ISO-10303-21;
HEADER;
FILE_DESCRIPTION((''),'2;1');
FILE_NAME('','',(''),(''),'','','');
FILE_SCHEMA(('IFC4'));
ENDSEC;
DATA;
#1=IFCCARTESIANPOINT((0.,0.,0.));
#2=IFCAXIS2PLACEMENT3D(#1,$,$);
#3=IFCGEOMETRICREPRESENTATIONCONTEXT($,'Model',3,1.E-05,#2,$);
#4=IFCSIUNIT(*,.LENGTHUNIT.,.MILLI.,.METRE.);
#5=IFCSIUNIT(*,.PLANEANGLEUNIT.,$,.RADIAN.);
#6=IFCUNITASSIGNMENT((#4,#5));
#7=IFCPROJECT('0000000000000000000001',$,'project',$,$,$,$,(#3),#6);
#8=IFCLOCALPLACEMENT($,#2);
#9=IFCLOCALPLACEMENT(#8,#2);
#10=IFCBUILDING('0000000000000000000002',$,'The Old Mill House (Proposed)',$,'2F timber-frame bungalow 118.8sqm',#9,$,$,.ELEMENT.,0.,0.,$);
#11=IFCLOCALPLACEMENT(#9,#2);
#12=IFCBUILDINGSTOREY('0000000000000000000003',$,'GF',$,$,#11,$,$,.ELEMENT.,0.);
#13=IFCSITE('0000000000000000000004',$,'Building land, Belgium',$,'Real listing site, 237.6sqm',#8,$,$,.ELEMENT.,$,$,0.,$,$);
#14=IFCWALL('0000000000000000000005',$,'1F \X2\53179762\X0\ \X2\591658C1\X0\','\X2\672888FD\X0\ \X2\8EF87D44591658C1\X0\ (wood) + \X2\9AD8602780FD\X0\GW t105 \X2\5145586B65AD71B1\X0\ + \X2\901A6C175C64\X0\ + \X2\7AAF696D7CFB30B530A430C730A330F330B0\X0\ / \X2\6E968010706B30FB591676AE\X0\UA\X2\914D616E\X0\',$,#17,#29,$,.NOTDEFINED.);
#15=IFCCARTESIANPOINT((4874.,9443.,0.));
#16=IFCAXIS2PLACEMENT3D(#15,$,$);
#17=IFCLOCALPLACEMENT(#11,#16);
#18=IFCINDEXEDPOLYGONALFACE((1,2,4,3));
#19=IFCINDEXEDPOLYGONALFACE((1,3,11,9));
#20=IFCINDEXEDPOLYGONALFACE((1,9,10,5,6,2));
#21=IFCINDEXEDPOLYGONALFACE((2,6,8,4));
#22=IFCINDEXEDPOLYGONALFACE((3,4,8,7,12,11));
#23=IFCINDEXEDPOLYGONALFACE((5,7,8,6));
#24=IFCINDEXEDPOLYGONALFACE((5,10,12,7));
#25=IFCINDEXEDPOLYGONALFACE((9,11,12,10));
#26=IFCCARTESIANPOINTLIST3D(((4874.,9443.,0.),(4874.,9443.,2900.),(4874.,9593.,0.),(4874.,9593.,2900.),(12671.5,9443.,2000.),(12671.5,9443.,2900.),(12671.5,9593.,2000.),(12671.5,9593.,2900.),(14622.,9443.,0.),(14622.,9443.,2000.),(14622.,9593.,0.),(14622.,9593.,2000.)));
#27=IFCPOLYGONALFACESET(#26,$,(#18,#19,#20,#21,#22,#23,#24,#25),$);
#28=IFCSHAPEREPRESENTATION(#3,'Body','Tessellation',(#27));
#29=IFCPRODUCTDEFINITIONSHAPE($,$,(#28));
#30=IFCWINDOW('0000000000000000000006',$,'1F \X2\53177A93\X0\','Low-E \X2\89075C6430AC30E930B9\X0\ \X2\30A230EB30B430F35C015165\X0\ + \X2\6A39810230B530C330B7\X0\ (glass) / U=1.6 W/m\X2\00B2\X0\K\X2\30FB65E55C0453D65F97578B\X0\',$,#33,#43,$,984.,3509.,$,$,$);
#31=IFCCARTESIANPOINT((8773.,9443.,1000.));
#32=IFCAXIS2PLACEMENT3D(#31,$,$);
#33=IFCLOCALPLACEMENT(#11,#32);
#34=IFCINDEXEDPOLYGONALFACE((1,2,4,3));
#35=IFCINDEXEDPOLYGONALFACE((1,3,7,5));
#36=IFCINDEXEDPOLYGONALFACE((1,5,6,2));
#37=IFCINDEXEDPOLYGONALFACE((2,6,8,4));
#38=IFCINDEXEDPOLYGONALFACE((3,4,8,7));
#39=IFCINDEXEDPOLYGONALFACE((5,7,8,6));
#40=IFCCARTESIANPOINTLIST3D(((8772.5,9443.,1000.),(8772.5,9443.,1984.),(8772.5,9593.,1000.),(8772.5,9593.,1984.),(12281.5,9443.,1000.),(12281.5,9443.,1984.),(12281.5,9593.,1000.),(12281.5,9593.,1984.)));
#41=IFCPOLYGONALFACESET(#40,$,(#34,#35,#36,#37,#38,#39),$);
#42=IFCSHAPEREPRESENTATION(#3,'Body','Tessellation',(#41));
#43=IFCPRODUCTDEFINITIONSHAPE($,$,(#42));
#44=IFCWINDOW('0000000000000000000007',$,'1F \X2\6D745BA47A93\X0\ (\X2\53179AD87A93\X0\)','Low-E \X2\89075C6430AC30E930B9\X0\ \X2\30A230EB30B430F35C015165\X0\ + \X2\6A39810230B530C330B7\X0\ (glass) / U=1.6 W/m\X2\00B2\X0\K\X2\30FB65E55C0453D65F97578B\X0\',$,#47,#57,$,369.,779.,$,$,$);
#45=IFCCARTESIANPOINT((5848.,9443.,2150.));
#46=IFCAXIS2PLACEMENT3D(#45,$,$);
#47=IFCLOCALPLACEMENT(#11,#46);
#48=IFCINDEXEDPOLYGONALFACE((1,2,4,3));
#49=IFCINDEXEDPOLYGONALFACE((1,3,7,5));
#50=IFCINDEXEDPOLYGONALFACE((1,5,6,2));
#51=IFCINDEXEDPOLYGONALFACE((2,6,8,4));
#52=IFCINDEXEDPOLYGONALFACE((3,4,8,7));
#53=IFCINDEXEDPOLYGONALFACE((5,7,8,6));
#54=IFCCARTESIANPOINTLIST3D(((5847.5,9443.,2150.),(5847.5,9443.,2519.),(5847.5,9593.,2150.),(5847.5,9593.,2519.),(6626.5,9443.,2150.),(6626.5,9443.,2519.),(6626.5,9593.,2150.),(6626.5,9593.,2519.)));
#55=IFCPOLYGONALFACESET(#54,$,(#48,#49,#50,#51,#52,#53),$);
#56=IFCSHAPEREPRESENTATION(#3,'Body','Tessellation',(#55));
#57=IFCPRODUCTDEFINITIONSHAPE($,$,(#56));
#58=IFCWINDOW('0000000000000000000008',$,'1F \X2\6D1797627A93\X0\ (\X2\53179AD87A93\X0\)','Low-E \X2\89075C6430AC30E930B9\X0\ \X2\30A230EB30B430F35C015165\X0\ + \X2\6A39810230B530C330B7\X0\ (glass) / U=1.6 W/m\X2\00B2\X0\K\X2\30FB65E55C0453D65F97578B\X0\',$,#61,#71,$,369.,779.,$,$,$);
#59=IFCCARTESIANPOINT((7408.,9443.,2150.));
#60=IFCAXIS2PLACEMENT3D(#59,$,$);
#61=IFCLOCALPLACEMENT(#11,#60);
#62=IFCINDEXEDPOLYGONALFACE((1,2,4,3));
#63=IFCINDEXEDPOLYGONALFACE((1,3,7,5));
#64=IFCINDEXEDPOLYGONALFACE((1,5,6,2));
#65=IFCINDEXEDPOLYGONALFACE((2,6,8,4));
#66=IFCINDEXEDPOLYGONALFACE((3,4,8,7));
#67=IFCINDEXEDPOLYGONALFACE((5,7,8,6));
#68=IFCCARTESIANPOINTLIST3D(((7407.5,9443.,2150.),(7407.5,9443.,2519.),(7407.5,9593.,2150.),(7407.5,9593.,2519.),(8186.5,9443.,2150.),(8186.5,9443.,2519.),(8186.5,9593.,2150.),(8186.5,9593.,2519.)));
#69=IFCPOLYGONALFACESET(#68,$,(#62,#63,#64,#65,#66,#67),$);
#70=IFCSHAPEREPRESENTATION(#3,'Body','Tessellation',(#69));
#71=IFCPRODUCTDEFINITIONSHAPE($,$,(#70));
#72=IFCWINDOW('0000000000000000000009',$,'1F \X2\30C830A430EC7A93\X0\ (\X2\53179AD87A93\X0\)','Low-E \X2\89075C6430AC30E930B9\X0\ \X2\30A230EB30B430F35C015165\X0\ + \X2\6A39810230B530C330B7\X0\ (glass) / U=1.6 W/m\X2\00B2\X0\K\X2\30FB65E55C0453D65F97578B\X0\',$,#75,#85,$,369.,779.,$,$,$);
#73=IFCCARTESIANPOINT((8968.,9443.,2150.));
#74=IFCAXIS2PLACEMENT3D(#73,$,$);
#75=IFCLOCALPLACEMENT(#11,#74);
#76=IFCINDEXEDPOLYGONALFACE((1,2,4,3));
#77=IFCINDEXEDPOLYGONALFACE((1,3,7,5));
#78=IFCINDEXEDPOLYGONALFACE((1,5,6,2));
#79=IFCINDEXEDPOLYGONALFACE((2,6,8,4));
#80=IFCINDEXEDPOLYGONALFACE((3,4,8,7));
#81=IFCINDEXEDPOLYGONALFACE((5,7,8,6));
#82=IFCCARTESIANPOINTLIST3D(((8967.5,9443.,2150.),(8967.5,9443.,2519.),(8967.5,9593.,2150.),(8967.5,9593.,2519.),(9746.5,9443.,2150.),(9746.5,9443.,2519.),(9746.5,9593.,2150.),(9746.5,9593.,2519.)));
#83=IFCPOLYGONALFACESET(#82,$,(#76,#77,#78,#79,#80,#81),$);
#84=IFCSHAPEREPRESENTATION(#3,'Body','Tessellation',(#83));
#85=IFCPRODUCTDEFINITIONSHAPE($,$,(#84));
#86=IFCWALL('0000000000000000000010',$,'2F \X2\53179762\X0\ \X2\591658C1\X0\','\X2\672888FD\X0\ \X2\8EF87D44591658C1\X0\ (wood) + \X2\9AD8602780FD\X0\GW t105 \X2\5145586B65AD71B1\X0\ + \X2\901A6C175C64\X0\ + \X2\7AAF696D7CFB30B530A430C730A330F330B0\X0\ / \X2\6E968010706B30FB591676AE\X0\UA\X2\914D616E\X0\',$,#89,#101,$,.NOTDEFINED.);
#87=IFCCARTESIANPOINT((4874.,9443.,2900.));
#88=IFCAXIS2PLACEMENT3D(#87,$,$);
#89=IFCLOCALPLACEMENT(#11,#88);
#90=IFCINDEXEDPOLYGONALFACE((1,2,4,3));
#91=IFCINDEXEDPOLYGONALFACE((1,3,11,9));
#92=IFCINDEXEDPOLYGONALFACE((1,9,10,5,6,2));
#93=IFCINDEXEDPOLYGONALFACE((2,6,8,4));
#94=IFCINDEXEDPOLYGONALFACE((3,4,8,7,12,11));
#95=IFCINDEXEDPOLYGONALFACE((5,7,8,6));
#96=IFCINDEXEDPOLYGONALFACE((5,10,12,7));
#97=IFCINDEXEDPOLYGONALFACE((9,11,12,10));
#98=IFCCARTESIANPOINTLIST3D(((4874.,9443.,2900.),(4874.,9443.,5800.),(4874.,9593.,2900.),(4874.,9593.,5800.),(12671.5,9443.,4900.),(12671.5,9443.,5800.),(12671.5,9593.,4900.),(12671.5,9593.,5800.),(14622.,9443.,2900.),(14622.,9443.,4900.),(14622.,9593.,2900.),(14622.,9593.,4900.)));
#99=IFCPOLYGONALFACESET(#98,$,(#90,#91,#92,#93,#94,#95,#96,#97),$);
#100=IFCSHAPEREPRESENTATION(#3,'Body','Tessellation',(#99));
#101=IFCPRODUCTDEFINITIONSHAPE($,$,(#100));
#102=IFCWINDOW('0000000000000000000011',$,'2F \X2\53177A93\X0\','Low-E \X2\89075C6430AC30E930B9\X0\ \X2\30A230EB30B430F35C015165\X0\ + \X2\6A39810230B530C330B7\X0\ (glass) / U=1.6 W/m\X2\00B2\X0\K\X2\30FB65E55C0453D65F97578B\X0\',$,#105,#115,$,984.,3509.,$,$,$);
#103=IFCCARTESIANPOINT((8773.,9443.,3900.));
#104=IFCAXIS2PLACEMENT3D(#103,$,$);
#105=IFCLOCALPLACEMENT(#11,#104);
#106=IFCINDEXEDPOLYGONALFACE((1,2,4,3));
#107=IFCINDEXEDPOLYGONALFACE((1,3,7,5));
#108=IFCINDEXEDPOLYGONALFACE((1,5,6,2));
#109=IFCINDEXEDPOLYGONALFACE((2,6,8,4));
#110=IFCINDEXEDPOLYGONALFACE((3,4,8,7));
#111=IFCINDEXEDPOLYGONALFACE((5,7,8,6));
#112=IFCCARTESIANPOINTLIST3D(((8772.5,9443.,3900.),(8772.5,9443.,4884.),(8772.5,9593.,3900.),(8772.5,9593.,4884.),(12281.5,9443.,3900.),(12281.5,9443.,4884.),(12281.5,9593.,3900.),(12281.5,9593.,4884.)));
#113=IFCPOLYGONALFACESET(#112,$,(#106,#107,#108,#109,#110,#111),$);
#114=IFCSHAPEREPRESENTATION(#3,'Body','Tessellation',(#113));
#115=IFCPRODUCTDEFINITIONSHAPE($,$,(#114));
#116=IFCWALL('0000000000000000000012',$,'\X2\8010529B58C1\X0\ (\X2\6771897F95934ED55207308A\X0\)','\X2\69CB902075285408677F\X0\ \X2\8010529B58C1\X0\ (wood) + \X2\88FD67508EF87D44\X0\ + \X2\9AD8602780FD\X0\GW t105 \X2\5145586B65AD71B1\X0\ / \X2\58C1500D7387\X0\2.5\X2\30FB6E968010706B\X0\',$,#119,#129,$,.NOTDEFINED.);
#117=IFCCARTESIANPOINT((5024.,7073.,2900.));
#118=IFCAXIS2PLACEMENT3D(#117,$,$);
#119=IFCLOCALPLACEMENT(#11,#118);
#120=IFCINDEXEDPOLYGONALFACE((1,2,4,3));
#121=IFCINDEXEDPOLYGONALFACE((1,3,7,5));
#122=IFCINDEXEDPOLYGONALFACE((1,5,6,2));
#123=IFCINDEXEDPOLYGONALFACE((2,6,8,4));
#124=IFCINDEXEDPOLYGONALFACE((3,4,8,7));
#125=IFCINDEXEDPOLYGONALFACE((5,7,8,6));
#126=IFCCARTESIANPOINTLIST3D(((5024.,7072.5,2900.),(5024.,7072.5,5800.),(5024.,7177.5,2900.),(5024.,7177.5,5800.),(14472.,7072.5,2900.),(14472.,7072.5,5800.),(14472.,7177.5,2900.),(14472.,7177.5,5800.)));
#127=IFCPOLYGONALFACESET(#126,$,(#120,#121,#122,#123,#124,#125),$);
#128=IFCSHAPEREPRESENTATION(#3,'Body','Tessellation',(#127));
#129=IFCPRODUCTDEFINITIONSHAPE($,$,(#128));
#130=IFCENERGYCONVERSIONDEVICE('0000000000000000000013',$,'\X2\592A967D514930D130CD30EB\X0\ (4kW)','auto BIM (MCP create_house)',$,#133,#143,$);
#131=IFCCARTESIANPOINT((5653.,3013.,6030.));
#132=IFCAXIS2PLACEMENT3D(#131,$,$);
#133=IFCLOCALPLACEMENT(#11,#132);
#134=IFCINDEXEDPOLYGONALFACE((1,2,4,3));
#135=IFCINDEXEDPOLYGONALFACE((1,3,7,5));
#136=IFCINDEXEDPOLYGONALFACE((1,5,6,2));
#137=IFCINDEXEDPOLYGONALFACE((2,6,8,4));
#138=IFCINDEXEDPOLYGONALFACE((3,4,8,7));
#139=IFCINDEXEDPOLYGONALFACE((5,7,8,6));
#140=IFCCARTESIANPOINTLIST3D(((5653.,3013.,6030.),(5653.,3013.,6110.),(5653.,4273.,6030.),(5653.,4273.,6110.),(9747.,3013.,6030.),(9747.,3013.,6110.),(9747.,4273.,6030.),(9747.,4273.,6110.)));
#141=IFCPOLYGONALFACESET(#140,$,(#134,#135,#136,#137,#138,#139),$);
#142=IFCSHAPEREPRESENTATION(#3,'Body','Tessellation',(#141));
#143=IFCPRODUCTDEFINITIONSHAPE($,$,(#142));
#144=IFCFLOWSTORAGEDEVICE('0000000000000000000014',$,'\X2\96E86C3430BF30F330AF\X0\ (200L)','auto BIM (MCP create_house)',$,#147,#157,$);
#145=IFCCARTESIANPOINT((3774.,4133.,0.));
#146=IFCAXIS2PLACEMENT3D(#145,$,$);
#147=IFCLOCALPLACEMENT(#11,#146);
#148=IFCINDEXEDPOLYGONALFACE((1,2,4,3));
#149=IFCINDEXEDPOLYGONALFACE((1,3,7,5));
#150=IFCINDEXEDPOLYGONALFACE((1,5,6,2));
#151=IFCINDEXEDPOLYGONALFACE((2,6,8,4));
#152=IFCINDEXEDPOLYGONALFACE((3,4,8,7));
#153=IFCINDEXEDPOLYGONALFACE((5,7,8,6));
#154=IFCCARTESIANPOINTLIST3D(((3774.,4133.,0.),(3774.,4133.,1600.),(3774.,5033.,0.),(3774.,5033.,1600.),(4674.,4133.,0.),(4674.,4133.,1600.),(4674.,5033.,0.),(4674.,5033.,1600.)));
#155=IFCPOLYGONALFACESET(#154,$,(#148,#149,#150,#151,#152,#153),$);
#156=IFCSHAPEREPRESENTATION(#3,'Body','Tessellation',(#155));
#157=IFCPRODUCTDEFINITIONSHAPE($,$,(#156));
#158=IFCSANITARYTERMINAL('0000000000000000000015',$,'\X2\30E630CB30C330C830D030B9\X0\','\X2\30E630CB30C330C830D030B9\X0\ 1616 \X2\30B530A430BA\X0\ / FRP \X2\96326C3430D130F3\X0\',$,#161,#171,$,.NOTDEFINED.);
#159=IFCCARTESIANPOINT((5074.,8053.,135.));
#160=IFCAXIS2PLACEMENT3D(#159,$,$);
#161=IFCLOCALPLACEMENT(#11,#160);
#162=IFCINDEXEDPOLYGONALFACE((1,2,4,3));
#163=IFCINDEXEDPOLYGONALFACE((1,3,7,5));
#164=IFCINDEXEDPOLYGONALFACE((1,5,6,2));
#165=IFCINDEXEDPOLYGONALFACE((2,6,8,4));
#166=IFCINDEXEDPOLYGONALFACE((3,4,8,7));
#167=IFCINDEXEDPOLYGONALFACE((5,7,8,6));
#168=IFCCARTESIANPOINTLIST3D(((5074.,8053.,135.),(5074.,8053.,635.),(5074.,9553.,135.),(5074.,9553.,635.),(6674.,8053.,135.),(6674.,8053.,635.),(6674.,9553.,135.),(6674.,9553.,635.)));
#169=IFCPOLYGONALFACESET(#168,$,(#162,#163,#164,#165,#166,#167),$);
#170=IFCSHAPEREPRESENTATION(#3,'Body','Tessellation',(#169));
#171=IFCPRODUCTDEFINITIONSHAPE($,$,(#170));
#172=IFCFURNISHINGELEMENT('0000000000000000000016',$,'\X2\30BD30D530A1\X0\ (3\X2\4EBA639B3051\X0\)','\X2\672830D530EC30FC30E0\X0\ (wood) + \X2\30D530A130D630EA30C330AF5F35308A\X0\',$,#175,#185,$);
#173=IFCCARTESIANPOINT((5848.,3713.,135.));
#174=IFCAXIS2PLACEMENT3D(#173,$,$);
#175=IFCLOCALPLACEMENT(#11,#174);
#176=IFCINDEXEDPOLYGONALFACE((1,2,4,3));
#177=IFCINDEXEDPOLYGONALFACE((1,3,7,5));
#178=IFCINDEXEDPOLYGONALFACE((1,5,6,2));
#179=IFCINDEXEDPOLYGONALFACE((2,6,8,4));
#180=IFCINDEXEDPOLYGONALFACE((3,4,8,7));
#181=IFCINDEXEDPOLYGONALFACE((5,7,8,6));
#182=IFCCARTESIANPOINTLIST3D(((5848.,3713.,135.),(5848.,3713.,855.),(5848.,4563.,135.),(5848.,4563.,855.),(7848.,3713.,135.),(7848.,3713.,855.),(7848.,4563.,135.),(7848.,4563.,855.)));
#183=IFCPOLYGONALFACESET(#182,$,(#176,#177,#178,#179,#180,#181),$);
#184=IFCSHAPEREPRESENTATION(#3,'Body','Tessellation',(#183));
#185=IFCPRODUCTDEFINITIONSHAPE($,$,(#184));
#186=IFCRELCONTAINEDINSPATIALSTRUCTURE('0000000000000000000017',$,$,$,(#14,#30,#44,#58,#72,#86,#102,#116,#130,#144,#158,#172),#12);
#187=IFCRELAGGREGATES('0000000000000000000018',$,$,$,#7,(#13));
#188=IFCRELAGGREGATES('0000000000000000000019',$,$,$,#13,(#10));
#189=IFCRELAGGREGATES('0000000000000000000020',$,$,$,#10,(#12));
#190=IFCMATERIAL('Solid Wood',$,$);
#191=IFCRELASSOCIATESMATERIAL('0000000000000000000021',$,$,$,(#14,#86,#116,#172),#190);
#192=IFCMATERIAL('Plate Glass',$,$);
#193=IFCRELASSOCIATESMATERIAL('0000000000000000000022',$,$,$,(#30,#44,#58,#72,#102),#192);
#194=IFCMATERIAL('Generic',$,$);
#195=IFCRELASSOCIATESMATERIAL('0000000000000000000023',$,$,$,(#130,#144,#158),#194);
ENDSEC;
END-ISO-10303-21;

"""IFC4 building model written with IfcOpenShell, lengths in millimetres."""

from ifc_helpers import new_model, si_unit, frame, frame_2d, origin, place, context, project, spatial, rectangle, extrude, material, element, fill, save


model = new_model("IFC4")

# Units and contexts
model_context = context("Model", 3, precision=1e-05, world=origin())
ifc_project = project(units=[si_unit("LENGTHUNIT", "METRE", prefix="MILLI"), si_unit("PLANEANGLEUNIT", "RADIAN")], contexts=[model_context])

# Site, building, storey
site_placement = place(None, origin())
site = spatial("IfcSite", under=ifc_project, at=site_placement, Name="Building land, Belgium", ObjectType="Real listing site, 237.6sqm", CompositionType="ELEMENT", RefElevation=0.0)
building_placement = place(site_placement, origin())
building = spatial("IfcBuilding", under=site, at=building_placement, Name="The Old Mill House (Proposed)", ObjectType="2F timber-frame bungalow 118.8sqm", CompositionType="ELEMENT", ElevationOfRefHeight=0.0, ElevationOfTerrain=0.0)
storey_placement = place(building_placement, origin())
storey = spatial("IfcBuildingStorey", under=building, at=storey_placement, Name="GF", CompositionType="ELEMENT", Elevation=0.0)

# Wall, openings, windows
ifc_material_1 = material(Name="Solid Wood")
wall_1_placement = place(storey_placement, frame((4874.0, 9443.0, 0.0)))
wall_1 = element("IfcWall", 1, at=wall_1_placement, inside=storey, material=ifc_material_1, Name="1F 北面 外壁", Description="木製 軸組外壁 (wood) + 高性能GW t105 充填断熱 + 通気層 + 窯業系サイディング / 準耐火・外皮UA配慮", PredefinedType="NOTDEFINED", context=model_context, shape_type="SweptSolid", body=[
    extrude(rectangle(XDim=9748.0, YDim=150.0, at=frame_2d((4874.0, 75.0))), frame((4874.0, 9443.0, 0.0)), (0.0, 0.0, 1.0), 2900.0),
])
opening_1_placement = place(storey_placement, frame((8773.0, 9443.0, 1000.0)))
opening_1 = element("IfcOpeningElement", 2, at=opening_1_placement, cuts=wall_1, PredefinedType="NOTDEFINED", context=model_context, shape_type="SweptSolid", body=[
    extrude(rectangle(XDim=3509.0, YDim=150.0, at=frame_2d((1754.0, 75.0))), frame((8773.0, 9443.0, 1000.0)), (0.0, 0.0, 1.0), 984.0),
])
opening_2_placement = place(storey_placement, frame((5848.0, 9443.0, 2150.0)))
opening_2 = element("IfcOpeningElement", 3, at=opening_2_placement, cuts=wall_1, PredefinedType="NOTDEFINED", context=model_context, shape_type="SweptSolid", body=[
    extrude(rectangle(XDim=779.0, YDim=150.0, at=frame_2d((389.0, 75.0))), frame((5848.0, 9443.0, 2150.0)), (0.0, 0.0, 1.0), 369.0),
])
opening_3_placement = place(storey_placement, frame((7408.0, 9443.0, 2150.0)))
opening_3 = element("IfcOpeningElement", 4, at=opening_3_placement, cuts=wall_1, PredefinedType="NOTDEFINED", context=model_context, shape_type="SweptSolid", body=[
    extrude(rectangle(XDim=779.0, YDim=150.0, at=frame_2d((389.0, 75.0))), frame((7408.0, 9443.0, 2150.0)), (0.0, 0.0, 1.0), 369.0),
])
opening_4_placement = place(storey_placement, frame((8968.0, 9443.0, 2150.0)))
opening_4 = element("IfcOpeningElement", 5, at=opening_4_placement, cuts=wall_1, PredefinedType="NOTDEFINED", context=model_context, shape_type="SweptSolid", body=[
    extrude(rectangle(XDim=779.0, YDim=150.0, at=frame_2d((389.0, 75.0))), frame((8968.0, 9443.0, 2150.0)), (0.0, 0.0, 1.0), 369.0),
])
ifc_material_2 = material(Name="Plate Glass")
window_1_placement = place(storey_placement, frame((8773.0, 9443.0, 1000.0)))
window_1 = element("IfcWindow", 6, at=window_1_placement, inside=storey, material=ifc_material_2, Name="1F 北窓", Description="Low-E 複層ガラス アルゴン封入 + 樹脂サッシ (glass) / U=1.6 W/m²K・日射取得型", OverallHeight=984.0, OverallWidth=3509.0, context=model_context, shape_type="SweptSolid", body=[
    extrude(rectangle(XDim=3509.0, YDim=150.0, at=frame_2d((1754.0, 75.0))), frame((8773.0, 9443.0, 1000.0)), (0.0, 0.0, 1.0), 984.0),
])
fill(opening_1, window_1)
window_2_placement = place(storey_placement, frame((5848.0, 9443.0, 2150.0)))
window_2 = element("IfcWindow", 7, at=window_2_placement, inside=storey, material=ifc_material_2, Name="1F 浴室窓 (北高窓)", Description="Low-E 複層ガラス アルゴン封入 + 樹脂サッシ (glass) / U=1.6 W/m²K・日射取得型", OverallHeight=369.0, OverallWidth=779.0, context=model_context, shape_type="SweptSolid", body=[
    extrude(rectangle(XDim=779.0, YDim=150.0, at=frame_2d((389.0, 75.0))), frame((5848.0, 9443.0, 2150.0)), (0.0, 0.0, 1.0), 369.0),
])
fill(opening_2, window_2)
window_3_placement = place(storey_placement, frame((7408.0, 9443.0, 2150.0)))
window_3 = element("IfcWindow", 8, at=window_3_placement, inside=storey, material=ifc_material_2, Name="1F 洗面窓 (北高窓)", Description="Low-E 複層ガラス アルゴン封入 + 樹脂サッシ (glass) / U=1.6 W/m²K・日射取得型", OverallHeight=369.0, OverallWidth=779.0, context=model_context, shape_type="SweptSolid", body=[
    extrude(rectangle(XDim=779.0, YDim=150.0, at=frame_2d((389.0, 75.0))), frame((7408.0, 9443.0, 2150.0)), (0.0, 0.0, 1.0), 369.0),
])
fill(opening_3, window_3)
window_4_placement = place(storey_placement, frame((8968.0, 9443.0, 2150.0)))
window_4 = element("IfcWindow", 9, at=window_4_placement, inside=storey, material=ifc_material_2, Name="1F トイレ窓 (北高窓)", Description="Low-E 複層ガラス アルゴン封入 + 樹脂サッシ (glass) / U=1.6 W/m²K・日射取得型", OverallHeight=369.0, OverallWidth=779.0, context=model_context, shape_type="SweptSolid", body=[
    extrude(rectangle(XDim=779.0, YDim=150.0, at=frame_2d((389.0, 75.0))), frame((8968.0, 9443.0, 2150.0)), (0.0, 0.0, 1.0), 369.0),
])
fill(opening_4, window_4)

# Wall, opening, window
wall_2_placement = place(storey_placement, frame((4874.0, 9443.0, 2900.0)))
wall_2 = element("IfcWall", 10, at=wall_2_placement, inside=storey, material=ifc_material_1, Name="2F 北面 外壁", Description="木製 軸組外壁 (wood) + 高性能GW t105 充填断熱 + 通気層 + 窯業系サイディング / 準耐火・外皮UA配慮", PredefinedType="NOTDEFINED", context=model_context, shape_type="SweptSolid", body=[
    extrude(rectangle(XDim=9748.0, YDim=150.0, at=frame_2d((4874.0, 75.0))), frame((4874.0, 9443.0, 2900.0)), (0.0, 0.0, 1.0), 2900.0),
])
opening_5_placement = place(storey_placement, frame((8773.0, 9443.0, 3900.0)))
opening_5 = element("IfcOpeningElement", 11, at=opening_5_placement, cuts=wall_2, PredefinedType="NOTDEFINED", context=model_context, shape_type="SweptSolid", body=[
    extrude(rectangle(XDim=3509.0, YDim=150.0, at=frame_2d((1754.0, 75.0))), frame((8773.0, 9443.0, 3900.0)), (0.0, 0.0, 1.0), 984.0),
])
window_5_placement = place(storey_placement, frame((8773.0, 9443.0, 3900.0)))
window_5 = element("IfcWindow", 12, at=window_5_placement, inside=storey, material=ifc_material_2, Name="2F 北窓", Description="Low-E 複層ガラス アルゴン封入 + 樹脂サッシ (glass) / U=1.6 W/m²K・日射取得型", OverallHeight=984.0, OverallWidth=3509.0, context=model_context, shape_type="SweptSolid", body=[
    extrude(rectangle(XDim=3509.0, YDim=150.0, at=frame_2d((1754.0, 75.0))), frame((8773.0, 9443.0, 3900.0)), (0.0, 0.0, 1.0), 984.0),
])
fill(opening_5, window_5)

# Wall
wall_3_placement = place(storey_placement, frame((5024.0, 7073.0, 2900.0)))
element("IfcWall", 13, at=wall_3_placement, inside=storey, material=ifc_material_1, Name="耐力壁 (東西間仕切り)", Description="構造用合板 耐力壁 (wood) + 製材軸組 + 高性能GW t105 充填断熱 / 壁倍率2.5・準耐火", PredefinedType="NOTDEFINED", context=model_context, shape_type="SweptSolid", body=[
    extrude(rectangle(XDim=9448.0, YDim=105.0, at=frame_2d((4724.0, 52.0))), frame((5024.0, 7073.0, 2900.0)), (0.0, 0.0, 1.0), 2900.0),
])

# Energy conversion device
ifc_material_3 = material(Name="Generic")
energy_conversion_device_placement = place(storey_placement, frame((5653.0, 3013.0, 6030.0)))
element("IfcEnergyConversionDevice", 14, at=energy_conversion_device_placement, inside=storey, material=ifc_material_3, Name="太陽光パネル (4kW)", Description="auto BIM (MCP create_house)", context=model_context, shape_type="SweptSolid", body=[
    extrude(rectangle(XDim=4094.0, YDim=1260.0, at=frame_2d((2047.0, 630.0))), frame((5653.0, 3013.0, 6030.0)), (0.0, 0.0, 1.0), 80.0),
])

# Flow storage device
flow_storage_device_placement = place(storey_placement, frame((3774.0, 4133.0, 0.0)))
element("IfcFlowStorageDevice", 15, at=flow_storage_device_placement, inside=storey, material=ifc_material_3, Name="雨水タンク (200L)", Description="auto BIM (MCP create_house)", context=model_context, shape_type="SweptSolid", body=[
    extrude(rectangle(XDim=900.0, YDim=900.0, at=frame_2d((450.0, 450.0))), frame((3774.0, 4133.0, 0.0)), (0.0, 0.0, 1.0), 1600.0),
])

# Sanitary terminal
sanitary_terminal_placement = place(storey_placement, frame((5074.0, 8053.0, 135.0)))
element("IfcSanitaryTerminal", 16, at=sanitary_terminal_placement, inside=storey, material=ifc_material_3, Name="ユニットバス", Description="ユニットバス 1616 サイズ / FRP 防水パン", PredefinedType="NOTDEFINED", context=model_context, shape_type="SweptSolid", body=[
    extrude(rectangle(XDim=1600.0, YDim=1500.0, at=frame_2d((800.0, 750.0))), frame((5074.0, 8053.0, 135.0)), (0.0, 0.0, 1.0), 500.0),
])

# Furnishing element
furnishing_1_placement = place(storey_placement, frame((5848.0, 3713.0, 135.0)))
element("IfcFurnishingElement", 17, at=furnishing_1_placement, inside=storey, material=ifc_material_1, Name="ソファ (3人掛け)", Description="木フレーム (wood) + ファブリック張り", context=model_context, shape_type="SweptSolid", body=[
    extrude(rectangle(XDim=2000.0, YDim=850.0, at=frame_2d((1000.0, 425.0))), frame((5848.0, 3713.0, 135.0)), (0.0, 0.0, 1.0), 720.0),
])

save(model, "model.ifc")
